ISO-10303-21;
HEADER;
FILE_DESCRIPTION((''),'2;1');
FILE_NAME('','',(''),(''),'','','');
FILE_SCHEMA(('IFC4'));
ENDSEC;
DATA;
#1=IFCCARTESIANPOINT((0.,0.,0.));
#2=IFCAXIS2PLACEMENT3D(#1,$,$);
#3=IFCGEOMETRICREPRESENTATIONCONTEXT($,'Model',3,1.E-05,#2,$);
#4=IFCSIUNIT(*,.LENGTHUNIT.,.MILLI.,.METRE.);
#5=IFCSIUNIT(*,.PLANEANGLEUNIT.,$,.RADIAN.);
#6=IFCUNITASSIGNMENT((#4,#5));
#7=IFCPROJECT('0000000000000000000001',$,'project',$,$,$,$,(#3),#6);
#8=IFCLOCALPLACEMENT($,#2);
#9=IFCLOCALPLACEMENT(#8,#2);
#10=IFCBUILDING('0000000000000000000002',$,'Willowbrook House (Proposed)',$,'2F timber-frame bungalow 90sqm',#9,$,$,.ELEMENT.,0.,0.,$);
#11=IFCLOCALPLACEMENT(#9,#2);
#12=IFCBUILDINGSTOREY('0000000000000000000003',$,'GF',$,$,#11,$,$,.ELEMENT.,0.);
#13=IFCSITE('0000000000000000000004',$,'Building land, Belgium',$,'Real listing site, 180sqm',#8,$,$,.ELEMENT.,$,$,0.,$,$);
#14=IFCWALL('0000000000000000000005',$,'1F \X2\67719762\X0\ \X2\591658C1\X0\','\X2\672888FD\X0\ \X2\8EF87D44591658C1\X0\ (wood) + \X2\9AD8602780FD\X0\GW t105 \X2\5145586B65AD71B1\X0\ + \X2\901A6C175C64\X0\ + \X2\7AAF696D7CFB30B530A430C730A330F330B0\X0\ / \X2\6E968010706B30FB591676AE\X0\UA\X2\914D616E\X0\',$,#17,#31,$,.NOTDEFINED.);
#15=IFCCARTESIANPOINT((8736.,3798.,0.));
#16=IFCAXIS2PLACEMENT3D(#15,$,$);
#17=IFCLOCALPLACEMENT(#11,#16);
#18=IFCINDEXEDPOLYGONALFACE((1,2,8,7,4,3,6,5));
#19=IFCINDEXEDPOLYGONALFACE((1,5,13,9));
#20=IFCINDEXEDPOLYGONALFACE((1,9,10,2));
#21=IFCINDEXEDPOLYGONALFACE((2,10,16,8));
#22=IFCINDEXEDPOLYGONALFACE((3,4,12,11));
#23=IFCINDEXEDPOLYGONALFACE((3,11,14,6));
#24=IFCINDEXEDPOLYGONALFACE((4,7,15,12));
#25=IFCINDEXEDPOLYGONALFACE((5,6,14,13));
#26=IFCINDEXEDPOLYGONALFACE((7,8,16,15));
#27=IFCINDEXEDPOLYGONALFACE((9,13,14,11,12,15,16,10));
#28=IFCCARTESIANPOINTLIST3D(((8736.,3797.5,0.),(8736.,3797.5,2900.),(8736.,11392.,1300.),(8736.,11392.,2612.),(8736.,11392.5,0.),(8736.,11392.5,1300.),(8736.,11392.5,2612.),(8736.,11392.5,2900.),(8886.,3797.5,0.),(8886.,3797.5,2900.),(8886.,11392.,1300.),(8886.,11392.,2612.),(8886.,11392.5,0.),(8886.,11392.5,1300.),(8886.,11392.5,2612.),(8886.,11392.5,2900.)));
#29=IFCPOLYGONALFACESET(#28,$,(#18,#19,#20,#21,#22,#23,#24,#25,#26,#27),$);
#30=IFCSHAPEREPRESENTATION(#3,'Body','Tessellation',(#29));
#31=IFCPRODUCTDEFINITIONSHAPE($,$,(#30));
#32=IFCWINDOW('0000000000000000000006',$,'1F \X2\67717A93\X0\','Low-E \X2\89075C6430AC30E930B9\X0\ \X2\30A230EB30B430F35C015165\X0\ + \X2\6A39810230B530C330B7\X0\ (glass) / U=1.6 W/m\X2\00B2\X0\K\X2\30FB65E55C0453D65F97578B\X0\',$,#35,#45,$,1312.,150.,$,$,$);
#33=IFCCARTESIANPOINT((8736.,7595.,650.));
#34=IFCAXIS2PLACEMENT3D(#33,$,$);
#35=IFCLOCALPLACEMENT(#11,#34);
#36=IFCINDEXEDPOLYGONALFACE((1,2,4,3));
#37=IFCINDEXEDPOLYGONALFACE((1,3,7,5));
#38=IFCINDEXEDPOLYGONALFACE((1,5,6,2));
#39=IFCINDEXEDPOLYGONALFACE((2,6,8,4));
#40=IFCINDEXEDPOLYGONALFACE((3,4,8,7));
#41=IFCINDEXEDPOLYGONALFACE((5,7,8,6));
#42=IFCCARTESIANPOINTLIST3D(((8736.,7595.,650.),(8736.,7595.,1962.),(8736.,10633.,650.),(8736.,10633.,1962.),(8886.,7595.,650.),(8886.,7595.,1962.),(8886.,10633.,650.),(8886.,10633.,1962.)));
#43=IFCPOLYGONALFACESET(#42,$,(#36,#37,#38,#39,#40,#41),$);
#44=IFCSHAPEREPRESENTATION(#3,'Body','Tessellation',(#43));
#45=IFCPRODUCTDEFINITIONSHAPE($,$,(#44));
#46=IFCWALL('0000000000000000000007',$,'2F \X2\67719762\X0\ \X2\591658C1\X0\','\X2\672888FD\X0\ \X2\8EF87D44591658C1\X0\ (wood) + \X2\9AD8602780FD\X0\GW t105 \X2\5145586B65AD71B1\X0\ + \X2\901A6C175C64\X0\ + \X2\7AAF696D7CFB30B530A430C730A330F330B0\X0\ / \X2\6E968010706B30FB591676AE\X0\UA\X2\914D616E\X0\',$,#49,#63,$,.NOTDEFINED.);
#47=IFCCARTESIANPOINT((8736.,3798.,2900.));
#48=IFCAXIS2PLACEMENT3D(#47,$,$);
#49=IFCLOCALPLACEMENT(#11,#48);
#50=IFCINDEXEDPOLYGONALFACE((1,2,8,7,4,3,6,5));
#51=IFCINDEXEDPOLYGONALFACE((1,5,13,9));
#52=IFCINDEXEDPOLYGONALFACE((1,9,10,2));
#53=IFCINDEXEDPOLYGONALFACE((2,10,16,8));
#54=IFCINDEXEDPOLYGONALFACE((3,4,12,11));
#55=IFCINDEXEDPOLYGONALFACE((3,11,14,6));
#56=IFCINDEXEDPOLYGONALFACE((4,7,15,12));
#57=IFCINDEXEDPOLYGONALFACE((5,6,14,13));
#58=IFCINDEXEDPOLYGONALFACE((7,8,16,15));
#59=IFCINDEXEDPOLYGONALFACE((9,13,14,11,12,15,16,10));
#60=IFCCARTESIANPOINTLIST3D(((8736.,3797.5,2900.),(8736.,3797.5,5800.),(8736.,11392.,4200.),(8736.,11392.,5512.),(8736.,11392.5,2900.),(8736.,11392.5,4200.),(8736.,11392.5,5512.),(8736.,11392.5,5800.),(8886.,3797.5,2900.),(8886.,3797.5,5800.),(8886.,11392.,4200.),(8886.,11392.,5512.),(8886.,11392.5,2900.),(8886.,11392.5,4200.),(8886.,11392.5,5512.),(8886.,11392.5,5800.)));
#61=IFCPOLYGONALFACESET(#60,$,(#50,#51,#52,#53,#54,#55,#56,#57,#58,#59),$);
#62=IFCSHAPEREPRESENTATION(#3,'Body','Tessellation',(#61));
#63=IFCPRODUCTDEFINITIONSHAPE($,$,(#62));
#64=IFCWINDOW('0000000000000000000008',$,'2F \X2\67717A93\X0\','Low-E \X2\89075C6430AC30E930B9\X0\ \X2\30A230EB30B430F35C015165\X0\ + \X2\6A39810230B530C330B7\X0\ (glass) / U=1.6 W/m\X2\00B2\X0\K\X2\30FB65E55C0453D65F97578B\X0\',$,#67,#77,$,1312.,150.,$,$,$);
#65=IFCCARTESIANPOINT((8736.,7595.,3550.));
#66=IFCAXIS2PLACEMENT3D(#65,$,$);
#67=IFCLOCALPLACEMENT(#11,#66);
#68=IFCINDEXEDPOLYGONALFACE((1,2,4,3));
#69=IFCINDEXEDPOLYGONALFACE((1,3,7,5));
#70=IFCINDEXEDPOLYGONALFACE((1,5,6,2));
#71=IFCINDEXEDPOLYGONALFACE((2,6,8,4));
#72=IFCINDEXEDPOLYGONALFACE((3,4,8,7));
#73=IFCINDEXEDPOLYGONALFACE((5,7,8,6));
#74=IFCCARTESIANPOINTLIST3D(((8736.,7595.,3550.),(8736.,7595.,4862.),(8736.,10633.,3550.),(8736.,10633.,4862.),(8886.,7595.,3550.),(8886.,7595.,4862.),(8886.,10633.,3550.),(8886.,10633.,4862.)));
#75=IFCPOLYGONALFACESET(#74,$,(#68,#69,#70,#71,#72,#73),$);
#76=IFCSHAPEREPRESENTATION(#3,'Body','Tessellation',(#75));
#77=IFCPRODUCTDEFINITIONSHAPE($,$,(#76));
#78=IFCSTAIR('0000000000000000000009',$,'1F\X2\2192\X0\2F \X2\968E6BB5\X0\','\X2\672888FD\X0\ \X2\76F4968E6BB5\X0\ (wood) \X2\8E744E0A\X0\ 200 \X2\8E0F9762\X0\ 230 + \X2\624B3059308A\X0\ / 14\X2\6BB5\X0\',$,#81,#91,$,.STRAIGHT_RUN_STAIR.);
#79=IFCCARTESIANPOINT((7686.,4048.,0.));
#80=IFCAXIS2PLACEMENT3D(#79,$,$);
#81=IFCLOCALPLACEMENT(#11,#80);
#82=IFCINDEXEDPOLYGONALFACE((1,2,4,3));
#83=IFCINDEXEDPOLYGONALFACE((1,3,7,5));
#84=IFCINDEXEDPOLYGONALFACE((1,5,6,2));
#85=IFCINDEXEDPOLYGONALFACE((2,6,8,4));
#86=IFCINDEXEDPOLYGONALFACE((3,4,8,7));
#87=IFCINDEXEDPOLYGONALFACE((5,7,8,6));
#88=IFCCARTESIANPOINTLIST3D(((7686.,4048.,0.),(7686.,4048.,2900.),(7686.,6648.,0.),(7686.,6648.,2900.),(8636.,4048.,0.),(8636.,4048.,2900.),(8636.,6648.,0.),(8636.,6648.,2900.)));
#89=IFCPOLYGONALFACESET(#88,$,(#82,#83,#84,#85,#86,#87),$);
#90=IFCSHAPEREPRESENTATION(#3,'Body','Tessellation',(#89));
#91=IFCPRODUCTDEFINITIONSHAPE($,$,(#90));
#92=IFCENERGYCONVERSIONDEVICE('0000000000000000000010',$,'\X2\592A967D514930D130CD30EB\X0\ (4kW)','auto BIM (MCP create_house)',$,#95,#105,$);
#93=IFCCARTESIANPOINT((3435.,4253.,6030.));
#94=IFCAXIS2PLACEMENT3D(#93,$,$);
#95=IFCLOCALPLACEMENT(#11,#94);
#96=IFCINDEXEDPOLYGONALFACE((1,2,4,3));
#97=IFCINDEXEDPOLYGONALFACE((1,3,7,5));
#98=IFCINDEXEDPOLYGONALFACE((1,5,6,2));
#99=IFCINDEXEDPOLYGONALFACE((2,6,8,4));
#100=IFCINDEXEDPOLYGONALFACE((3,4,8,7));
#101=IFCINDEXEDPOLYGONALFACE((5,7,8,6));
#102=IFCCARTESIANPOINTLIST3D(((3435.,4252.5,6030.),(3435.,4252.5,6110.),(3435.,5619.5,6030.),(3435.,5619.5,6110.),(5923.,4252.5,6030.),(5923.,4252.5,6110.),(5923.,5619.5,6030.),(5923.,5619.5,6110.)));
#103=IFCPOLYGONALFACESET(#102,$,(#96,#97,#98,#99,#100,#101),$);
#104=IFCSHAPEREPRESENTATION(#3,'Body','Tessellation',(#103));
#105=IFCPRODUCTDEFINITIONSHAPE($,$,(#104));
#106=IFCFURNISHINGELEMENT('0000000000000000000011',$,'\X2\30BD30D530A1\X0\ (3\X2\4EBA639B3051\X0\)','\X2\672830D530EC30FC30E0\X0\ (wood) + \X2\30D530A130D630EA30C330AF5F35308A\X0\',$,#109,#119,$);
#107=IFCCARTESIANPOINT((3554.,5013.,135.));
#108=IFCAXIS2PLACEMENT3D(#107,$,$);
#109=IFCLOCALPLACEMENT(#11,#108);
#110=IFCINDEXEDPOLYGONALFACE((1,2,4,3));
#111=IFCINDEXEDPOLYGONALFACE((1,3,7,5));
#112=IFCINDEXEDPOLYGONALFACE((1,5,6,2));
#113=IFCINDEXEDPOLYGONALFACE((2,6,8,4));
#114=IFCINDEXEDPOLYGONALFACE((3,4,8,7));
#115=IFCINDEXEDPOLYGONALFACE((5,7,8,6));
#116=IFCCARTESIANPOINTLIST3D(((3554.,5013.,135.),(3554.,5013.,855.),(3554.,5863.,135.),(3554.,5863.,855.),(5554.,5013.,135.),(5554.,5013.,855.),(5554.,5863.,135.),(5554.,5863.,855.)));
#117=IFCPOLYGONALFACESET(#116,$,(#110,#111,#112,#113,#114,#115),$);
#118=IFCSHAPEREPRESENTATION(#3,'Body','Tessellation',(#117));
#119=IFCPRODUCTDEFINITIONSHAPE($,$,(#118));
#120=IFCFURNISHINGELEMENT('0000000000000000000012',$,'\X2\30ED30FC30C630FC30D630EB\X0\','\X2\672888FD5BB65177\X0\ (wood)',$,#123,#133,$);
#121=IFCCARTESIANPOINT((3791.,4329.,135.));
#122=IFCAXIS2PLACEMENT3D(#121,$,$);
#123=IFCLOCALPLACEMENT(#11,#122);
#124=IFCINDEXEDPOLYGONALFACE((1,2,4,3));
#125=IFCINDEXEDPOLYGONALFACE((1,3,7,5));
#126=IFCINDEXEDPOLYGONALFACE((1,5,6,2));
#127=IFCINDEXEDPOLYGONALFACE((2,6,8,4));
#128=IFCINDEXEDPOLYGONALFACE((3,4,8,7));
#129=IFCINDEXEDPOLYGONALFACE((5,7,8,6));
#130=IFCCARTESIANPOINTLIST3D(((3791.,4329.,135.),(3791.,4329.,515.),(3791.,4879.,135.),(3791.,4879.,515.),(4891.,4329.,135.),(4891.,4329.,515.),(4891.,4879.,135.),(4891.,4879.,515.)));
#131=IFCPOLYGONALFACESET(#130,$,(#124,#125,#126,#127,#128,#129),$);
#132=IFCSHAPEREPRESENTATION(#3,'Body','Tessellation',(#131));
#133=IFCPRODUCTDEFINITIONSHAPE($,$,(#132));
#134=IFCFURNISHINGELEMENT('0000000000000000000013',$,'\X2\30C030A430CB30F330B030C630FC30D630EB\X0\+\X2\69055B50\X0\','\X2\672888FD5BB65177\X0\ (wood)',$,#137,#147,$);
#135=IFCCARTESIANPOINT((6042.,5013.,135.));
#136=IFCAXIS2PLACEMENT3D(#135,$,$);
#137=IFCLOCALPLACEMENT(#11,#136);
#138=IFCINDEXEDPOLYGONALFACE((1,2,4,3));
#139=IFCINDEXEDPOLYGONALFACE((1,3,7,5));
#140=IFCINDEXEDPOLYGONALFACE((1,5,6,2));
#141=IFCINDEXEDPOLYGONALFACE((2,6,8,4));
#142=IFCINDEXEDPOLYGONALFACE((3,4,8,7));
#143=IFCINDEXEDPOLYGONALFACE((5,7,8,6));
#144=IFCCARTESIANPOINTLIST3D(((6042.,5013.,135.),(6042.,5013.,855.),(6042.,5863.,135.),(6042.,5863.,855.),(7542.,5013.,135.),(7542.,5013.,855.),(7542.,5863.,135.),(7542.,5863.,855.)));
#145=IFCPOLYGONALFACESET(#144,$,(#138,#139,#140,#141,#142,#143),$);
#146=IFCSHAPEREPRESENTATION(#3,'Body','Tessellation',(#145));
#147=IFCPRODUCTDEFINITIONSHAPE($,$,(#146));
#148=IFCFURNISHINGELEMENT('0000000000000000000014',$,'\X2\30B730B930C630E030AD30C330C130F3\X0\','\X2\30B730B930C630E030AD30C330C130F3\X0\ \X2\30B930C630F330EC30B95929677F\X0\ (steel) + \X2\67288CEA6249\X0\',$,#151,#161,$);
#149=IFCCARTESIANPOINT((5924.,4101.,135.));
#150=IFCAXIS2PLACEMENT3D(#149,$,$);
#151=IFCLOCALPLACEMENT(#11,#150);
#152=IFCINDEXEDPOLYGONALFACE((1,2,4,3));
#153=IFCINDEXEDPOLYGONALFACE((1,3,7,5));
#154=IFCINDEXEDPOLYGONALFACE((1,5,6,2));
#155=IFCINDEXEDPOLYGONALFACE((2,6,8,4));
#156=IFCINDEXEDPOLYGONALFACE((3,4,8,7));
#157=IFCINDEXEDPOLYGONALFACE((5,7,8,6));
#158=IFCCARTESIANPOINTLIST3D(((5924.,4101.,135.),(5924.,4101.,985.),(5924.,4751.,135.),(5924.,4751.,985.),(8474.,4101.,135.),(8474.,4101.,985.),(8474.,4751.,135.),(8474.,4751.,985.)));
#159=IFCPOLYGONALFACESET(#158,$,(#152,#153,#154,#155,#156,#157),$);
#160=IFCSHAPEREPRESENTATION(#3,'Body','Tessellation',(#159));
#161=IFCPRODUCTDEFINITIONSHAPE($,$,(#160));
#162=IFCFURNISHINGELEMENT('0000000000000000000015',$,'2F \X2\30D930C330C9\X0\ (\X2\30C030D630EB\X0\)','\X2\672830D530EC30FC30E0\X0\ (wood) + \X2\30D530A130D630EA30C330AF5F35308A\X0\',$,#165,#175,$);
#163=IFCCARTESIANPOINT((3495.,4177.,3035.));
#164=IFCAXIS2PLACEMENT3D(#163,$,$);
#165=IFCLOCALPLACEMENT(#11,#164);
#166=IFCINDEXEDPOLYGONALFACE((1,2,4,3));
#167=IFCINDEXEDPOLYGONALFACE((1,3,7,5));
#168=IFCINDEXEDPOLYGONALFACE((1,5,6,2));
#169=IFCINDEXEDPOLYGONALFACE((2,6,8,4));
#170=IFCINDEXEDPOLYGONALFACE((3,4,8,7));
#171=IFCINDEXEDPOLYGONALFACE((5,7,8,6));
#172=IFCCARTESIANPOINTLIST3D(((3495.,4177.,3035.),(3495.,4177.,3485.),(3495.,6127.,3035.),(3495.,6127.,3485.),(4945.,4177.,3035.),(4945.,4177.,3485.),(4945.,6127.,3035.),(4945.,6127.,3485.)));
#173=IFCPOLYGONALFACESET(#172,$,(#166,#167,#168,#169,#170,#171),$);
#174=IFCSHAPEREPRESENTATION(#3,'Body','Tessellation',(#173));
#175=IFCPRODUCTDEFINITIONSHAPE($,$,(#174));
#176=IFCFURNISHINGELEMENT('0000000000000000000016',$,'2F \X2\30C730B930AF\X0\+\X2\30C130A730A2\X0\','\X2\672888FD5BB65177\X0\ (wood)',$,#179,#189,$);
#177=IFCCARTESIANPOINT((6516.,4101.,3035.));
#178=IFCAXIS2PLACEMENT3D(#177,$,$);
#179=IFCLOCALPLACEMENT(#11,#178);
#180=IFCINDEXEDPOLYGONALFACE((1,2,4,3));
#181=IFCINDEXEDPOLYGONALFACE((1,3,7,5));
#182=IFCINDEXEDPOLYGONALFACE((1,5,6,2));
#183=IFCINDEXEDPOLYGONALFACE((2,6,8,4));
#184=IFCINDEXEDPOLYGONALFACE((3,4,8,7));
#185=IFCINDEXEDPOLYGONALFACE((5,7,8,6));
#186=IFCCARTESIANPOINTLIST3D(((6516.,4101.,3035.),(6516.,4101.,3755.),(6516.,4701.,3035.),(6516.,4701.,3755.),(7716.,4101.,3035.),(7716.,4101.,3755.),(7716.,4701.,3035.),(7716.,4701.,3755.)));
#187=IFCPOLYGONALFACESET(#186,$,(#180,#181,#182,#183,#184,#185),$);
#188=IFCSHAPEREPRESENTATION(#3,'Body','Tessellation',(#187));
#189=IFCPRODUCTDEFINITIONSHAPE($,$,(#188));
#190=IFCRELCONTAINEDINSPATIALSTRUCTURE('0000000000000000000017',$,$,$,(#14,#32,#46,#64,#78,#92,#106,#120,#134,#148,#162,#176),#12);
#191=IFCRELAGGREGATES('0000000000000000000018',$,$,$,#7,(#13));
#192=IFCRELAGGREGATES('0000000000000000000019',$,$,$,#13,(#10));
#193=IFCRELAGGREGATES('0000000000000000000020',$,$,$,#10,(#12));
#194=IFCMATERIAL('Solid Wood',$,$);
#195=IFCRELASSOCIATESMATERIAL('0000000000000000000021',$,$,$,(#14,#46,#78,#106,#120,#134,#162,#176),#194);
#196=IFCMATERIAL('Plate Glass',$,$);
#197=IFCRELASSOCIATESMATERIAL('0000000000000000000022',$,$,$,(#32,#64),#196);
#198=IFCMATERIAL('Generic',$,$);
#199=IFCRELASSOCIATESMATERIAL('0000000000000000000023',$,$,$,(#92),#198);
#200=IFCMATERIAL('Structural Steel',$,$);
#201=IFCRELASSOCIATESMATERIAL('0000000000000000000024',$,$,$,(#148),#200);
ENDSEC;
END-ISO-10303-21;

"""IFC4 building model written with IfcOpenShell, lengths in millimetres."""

from ifc_helpers import new_model, si_unit, frame, frame_2d, origin, place, context, project, spatial, rectangle, extrude, material, element, fill, save


model = new_model("IFC4")

# Units and contexts
model_context = context("Model", 3, precision=1e-05, world=origin())
ifc_project = project(units=[si_unit("LENGTHUNIT", "METRE", prefix="MILLI"), si_unit("PLANEANGLEUNIT", "RADIAN")], contexts=[model_context])

# Site, building, storey
site_placement = place(None, origin())
site = spatial("IfcSite", under=ifc_project, at=site_placement, Name="Building land, Belgium", ObjectType="Real listing site, 180sqm", CompositionType="ELEMENT", RefElevation=0.0)
building_placement = place(site_placement, origin())
building = spatial("IfcBuilding", under=site, at=building_placement, Name="Willowbrook House (Proposed)", ObjectType="2F timber-frame bungalow 90sqm", CompositionType="ELEMENT", ElevationOfRefHeight=0.0, ElevationOfTerrain=0.0)
storey_placement = place(building_placement, origin())
storey = spatial("IfcBuildingStorey", under=building, at=storey_placement, Name="GF", CompositionType="ELEMENT", Elevation=0.0)

# Wall, opening, window
ifc_material_1 = material(Name="Solid Wood")
wall_1_placement = place(storey_placement, frame((8736.0, 3798.0, 0.0)))
wall_1 = element("IfcWall", 1, at=wall_1_placement, inside=storey, material=ifc_material_1, Name="1F 東面 外壁", Description="木製 軸組外壁 (wood) + 高性能GW t105 充填断熱 + 通気層 + 窯業系サイディング / 準耐火・外皮UA配慮", PredefinedType="NOTDEFINED", context=model_context, shape_type="SweptSolid", body=[
    extrude(rectangle(XDim=150.0, YDim=7595.0, at=frame_2d((75.0, 3797.0))), frame((8736.0, 3798.0, 0.0)), (0.0, 0.0, 1.0), 2900.0),
])
opening_1_placement = place(storey_placement, frame((8736.0, 7595.0, 650.0)))
opening_1 = element("IfcOpeningElement", 2, at=opening_1_placement, cuts=wall_1, PredefinedType="NOTDEFINED", context=model_context, shape_type="SweptSolid", body=[
    extrude(rectangle(XDim=150.0, YDim=3038.0, at=frame_2d((75.0, 1519.0))), frame((8736.0, 7595.0, 650.0)), (0.0, 0.0, 1.0), 1312.0),
])
ifc_material_2 = material(Name="Plate Glass")
window_1_placement = place(storey_placement, frame((8736.0, 7595.0, 650.0)))
window_1 = element("IfcWindow", 3, at=window_1_placement, inside=storey, material=ifc_material_2, Name="1F 東窓", Description="Low-E 複層ガラス アルゴン封入 + 樹脂サッシ (glass) / U=1.6 W/m²K・日射取得型", OverallHeight=1312.0, OverallWidth=150.0, context=model_context, shape_type="SweptSolid", body=[
    extrude(rectangle(XDim=150.0, YDim=3038.0, at=frame_2d((75.0, 1519.0))), frame((8736.0, 7595.0, 650.0)), (0.0, 0.0, 1.0), 1312.0),
])
fill(opening_1, window_1)

# Wall, opening, window
wall_2_placement = place(storey_placement, frame((8736.0, 3798.0, 2900.0)))
wall_2 = element("IfcWall", 4, at=wall_2_placement, inside=storey, material=ifc_material_1, Name="2F 東面 外壁", Description="木製 軸組外壁 (wood) + 高性能GW t105 充填断熱 + 通気層 + 窯業系サイディング / 準耐火・外皮UA配慮", PredefinedType="NOTDEFINED", context=model_context, shape_type="SweptSolid", body=[
    extrude(rectangle(XDim=150.0, YDim=7595.0, at=frame_2d((75.0, 3797.0))), frame((8736.0, 3798.0, 2900.0)), (0.0, 0.0, 1.0), 2900.0),
])
opening_2_placement = place(storey_placement, frame((8736.0, 7595.0, 3550.0)))
opening_2 = element("IfcOpeningElement", 5, at=opening_2_placement, cuts=wall_2, PredefinedType="NOTDEFINED", context=model_context, shape_type="SweptSolid", body=[
    extrude(rectangle(XDim=150.0, YDim=3038.0, at=frame_2d((75.0, 1519.0))), frame((8736.0, 7595.0, 3550.0)), (0.0, 0.0, 1.0), 1312.0),
])
window_2_placement = place(storey_placement, frame((8736.0, 7595.0, 3550.0)))
window_2 = element("IfcWindow", 6, at=window_2_placement, inside=storey, material=ifc_material_2, Name="2F 東窓", Description="Low-E 複層ガラス アルゴン封入 + 樹脂サッシ (glass) / U=1.6 W/m²K・日射取得型", OverallHeight=1312.0, OverallWidth=150.0, context=model_context, shape_type="SweptSolid", body=[
    extrude(rectangle(XDim=150.0, YDim=3038.0, at=frame_2d((75.0, 1519.0))), frame((8736.0, 7595.0, 3550.0)), (0.0, 0.0, 1.0), 1312.0),
])
fill(opening_2, window_2)

# Stair
stair_placement = place(storey_placement, frame((7686.0, 4048.0, 0.0)))
element("IfcStair", 7, at=stair_placement, inside=storey, material=ifc_material_1, Name="1F→2F 階段", Description="木製 直階段 (wood) 蹴上 200 踏面 230 + 手すり / 14段", PredefinedType="STRAIGHT_RUN_STAIR", context=model_context, shape_type="SweptSolid", body=[
    extrude(rectangle(XDim=950.0, YDim=2600.0, at=frame_2d((475.0, 1300.0))), frame((7686.0, 4048.0, 0.0)), (0.0, 0.0, 1.0), 2900.0),
])

# Energy conversion device
ifc_material_3 = material(Name="Generic")
energy_conversion_device_placement = place(storey_placement, frame((3435.0, 4253.0, 6030.0)))
element("IfcEnergyConversionDevice", 8, at=energy_conversion_device_placement, inside=storey, material=ifc_material_3, Name="太陽光パネル (4kW)", Description="auto BIM (MCP create_house)", context=model_context, shape_type="SweptSolid", body=[
    extrude(rectangle(XDim=2488.0, YDim=1367.0, at=frame_2d((1244.0, 683.0))), frame((3435.0, 4253.0, 6030.0)), (0.0, 0.0, 1.0), 80.0),
])

# Furnishing elements
furnishing_1_placement = place(storey_placement, frame((3554.0, 5013.0, 135.0)))
element("IfcFurnishingElement", 9, at=furnishing_1_placement, inside=storey, material=ifc_material_1, Name="ソファ (3人掛け)", Description="木フレーム (wood) + ファブリック張り", context=model_context, shape_type="SweptSolid", body=[
    extrude(rectangle(XDim=2000.0, YDim=850.0, at=frame_2d((1000.0, 425.0))), frame((3554.0, 5013.0, 135.0)), (0.0, 0.0, 1.0), 720.0),
])
furnishing_2_placement = place(storey_placement, frame((3791.0, 4329.0, 135.0)))
element("IfcFurnishingElement", 10, at=furnishing_2_placement, inside=storey, material=ifc_material_1, Name="ローテーブル", Description="木製家具 (wood)", context=model_context, shape_type="SweptSolid", body=[
    extrude(rectangle(XDim=1100.0, YDim=550.0, at=frame_2d((550.0, 275.0))), frame((3791.0, 4329.0, 135.0)), (0.0, 0.0, 1.0), 380.0),
])
furnishing_3_placement = place(storey_placement, frame((6042.0, 5013.0, 135.0)))
element("IfcFurnishingElement", 11, at=furnishing_3_placement, inside=storey, material=ifc_material_1, Name="ダイニングテーブル+椅子", Description="木製家具 (wood)", context=model_context, shape_type="SweptSolid", body=[
    extrude(rectangle(XDim=1500.0, YDim=850.0, at=frame_2d((750.0, 425.0))), frame((6042.0, 5013.0, 135.0)), (0.0, 0.0, 1.0), 720.0),
])
ifc_material_4 = material(Name="Structural Steel")
furnishing_4_placement = place(storey_placement, frame((5924.0, 4101.0, 135.0)))
element("IfcFurnishingElement", 12, at=furnishing_4_placement, inside=storey, material=ifc_material_4, Name="システムキッチン", Description="システムキッチン ステンレス天板 (steel) + 木質扉", context=model_context, shape_type="SweptSolid", body=[
    extrude(rectangle(XDim=2550.0, YDim=650.0, at=frame_2d((1275.0, 325.0))), frame((5924.0, 4101.0, 135.0)), (0.0, 0.0, 1.0), 850.0),
])
furnishing_5_placement = place(storey_placement, frame((3495.0, 4177.0, 3035.0)))
element("IfcFurnishingElement", 13, at=furnishing_5_placement, inside=storey, material=ifc_material_1, Name="2F ベッド (ダブル)", Description="木フレーム (wood) + ファブリック張り", context=model_context, shape_type="SweptSolid", body=[
    extrude(rectangle(XDim=1450.0, YDim=1950.0, at=frame_2d((725.0, 975.0))), frame((3495.0, 4177.0, 3035.0)), (0.0, 0.0, 1.0), 450.0),
])
furnishing_6_placement = place(storey_placement, frame((6516.0, 4101.0, 3035.0)))
element("IfcFurnishingElement", 14, at=furnishing_6_placement, inside=storey, material=ifc_material_1, Name="2F デスク+チェア", Description="木製家具 (wood)", context=model_context, shape_type="SweptSolid", body=[
    extrude(rectangle(XDim=1200.0, YDim=600.0, at=frame_2d((600.0, 300.0))), frame((6516.0, 4101.0, 3035.0)), (0.0, 0.0, 1.0), 720.0),
])

save(model, "model.ifc")
